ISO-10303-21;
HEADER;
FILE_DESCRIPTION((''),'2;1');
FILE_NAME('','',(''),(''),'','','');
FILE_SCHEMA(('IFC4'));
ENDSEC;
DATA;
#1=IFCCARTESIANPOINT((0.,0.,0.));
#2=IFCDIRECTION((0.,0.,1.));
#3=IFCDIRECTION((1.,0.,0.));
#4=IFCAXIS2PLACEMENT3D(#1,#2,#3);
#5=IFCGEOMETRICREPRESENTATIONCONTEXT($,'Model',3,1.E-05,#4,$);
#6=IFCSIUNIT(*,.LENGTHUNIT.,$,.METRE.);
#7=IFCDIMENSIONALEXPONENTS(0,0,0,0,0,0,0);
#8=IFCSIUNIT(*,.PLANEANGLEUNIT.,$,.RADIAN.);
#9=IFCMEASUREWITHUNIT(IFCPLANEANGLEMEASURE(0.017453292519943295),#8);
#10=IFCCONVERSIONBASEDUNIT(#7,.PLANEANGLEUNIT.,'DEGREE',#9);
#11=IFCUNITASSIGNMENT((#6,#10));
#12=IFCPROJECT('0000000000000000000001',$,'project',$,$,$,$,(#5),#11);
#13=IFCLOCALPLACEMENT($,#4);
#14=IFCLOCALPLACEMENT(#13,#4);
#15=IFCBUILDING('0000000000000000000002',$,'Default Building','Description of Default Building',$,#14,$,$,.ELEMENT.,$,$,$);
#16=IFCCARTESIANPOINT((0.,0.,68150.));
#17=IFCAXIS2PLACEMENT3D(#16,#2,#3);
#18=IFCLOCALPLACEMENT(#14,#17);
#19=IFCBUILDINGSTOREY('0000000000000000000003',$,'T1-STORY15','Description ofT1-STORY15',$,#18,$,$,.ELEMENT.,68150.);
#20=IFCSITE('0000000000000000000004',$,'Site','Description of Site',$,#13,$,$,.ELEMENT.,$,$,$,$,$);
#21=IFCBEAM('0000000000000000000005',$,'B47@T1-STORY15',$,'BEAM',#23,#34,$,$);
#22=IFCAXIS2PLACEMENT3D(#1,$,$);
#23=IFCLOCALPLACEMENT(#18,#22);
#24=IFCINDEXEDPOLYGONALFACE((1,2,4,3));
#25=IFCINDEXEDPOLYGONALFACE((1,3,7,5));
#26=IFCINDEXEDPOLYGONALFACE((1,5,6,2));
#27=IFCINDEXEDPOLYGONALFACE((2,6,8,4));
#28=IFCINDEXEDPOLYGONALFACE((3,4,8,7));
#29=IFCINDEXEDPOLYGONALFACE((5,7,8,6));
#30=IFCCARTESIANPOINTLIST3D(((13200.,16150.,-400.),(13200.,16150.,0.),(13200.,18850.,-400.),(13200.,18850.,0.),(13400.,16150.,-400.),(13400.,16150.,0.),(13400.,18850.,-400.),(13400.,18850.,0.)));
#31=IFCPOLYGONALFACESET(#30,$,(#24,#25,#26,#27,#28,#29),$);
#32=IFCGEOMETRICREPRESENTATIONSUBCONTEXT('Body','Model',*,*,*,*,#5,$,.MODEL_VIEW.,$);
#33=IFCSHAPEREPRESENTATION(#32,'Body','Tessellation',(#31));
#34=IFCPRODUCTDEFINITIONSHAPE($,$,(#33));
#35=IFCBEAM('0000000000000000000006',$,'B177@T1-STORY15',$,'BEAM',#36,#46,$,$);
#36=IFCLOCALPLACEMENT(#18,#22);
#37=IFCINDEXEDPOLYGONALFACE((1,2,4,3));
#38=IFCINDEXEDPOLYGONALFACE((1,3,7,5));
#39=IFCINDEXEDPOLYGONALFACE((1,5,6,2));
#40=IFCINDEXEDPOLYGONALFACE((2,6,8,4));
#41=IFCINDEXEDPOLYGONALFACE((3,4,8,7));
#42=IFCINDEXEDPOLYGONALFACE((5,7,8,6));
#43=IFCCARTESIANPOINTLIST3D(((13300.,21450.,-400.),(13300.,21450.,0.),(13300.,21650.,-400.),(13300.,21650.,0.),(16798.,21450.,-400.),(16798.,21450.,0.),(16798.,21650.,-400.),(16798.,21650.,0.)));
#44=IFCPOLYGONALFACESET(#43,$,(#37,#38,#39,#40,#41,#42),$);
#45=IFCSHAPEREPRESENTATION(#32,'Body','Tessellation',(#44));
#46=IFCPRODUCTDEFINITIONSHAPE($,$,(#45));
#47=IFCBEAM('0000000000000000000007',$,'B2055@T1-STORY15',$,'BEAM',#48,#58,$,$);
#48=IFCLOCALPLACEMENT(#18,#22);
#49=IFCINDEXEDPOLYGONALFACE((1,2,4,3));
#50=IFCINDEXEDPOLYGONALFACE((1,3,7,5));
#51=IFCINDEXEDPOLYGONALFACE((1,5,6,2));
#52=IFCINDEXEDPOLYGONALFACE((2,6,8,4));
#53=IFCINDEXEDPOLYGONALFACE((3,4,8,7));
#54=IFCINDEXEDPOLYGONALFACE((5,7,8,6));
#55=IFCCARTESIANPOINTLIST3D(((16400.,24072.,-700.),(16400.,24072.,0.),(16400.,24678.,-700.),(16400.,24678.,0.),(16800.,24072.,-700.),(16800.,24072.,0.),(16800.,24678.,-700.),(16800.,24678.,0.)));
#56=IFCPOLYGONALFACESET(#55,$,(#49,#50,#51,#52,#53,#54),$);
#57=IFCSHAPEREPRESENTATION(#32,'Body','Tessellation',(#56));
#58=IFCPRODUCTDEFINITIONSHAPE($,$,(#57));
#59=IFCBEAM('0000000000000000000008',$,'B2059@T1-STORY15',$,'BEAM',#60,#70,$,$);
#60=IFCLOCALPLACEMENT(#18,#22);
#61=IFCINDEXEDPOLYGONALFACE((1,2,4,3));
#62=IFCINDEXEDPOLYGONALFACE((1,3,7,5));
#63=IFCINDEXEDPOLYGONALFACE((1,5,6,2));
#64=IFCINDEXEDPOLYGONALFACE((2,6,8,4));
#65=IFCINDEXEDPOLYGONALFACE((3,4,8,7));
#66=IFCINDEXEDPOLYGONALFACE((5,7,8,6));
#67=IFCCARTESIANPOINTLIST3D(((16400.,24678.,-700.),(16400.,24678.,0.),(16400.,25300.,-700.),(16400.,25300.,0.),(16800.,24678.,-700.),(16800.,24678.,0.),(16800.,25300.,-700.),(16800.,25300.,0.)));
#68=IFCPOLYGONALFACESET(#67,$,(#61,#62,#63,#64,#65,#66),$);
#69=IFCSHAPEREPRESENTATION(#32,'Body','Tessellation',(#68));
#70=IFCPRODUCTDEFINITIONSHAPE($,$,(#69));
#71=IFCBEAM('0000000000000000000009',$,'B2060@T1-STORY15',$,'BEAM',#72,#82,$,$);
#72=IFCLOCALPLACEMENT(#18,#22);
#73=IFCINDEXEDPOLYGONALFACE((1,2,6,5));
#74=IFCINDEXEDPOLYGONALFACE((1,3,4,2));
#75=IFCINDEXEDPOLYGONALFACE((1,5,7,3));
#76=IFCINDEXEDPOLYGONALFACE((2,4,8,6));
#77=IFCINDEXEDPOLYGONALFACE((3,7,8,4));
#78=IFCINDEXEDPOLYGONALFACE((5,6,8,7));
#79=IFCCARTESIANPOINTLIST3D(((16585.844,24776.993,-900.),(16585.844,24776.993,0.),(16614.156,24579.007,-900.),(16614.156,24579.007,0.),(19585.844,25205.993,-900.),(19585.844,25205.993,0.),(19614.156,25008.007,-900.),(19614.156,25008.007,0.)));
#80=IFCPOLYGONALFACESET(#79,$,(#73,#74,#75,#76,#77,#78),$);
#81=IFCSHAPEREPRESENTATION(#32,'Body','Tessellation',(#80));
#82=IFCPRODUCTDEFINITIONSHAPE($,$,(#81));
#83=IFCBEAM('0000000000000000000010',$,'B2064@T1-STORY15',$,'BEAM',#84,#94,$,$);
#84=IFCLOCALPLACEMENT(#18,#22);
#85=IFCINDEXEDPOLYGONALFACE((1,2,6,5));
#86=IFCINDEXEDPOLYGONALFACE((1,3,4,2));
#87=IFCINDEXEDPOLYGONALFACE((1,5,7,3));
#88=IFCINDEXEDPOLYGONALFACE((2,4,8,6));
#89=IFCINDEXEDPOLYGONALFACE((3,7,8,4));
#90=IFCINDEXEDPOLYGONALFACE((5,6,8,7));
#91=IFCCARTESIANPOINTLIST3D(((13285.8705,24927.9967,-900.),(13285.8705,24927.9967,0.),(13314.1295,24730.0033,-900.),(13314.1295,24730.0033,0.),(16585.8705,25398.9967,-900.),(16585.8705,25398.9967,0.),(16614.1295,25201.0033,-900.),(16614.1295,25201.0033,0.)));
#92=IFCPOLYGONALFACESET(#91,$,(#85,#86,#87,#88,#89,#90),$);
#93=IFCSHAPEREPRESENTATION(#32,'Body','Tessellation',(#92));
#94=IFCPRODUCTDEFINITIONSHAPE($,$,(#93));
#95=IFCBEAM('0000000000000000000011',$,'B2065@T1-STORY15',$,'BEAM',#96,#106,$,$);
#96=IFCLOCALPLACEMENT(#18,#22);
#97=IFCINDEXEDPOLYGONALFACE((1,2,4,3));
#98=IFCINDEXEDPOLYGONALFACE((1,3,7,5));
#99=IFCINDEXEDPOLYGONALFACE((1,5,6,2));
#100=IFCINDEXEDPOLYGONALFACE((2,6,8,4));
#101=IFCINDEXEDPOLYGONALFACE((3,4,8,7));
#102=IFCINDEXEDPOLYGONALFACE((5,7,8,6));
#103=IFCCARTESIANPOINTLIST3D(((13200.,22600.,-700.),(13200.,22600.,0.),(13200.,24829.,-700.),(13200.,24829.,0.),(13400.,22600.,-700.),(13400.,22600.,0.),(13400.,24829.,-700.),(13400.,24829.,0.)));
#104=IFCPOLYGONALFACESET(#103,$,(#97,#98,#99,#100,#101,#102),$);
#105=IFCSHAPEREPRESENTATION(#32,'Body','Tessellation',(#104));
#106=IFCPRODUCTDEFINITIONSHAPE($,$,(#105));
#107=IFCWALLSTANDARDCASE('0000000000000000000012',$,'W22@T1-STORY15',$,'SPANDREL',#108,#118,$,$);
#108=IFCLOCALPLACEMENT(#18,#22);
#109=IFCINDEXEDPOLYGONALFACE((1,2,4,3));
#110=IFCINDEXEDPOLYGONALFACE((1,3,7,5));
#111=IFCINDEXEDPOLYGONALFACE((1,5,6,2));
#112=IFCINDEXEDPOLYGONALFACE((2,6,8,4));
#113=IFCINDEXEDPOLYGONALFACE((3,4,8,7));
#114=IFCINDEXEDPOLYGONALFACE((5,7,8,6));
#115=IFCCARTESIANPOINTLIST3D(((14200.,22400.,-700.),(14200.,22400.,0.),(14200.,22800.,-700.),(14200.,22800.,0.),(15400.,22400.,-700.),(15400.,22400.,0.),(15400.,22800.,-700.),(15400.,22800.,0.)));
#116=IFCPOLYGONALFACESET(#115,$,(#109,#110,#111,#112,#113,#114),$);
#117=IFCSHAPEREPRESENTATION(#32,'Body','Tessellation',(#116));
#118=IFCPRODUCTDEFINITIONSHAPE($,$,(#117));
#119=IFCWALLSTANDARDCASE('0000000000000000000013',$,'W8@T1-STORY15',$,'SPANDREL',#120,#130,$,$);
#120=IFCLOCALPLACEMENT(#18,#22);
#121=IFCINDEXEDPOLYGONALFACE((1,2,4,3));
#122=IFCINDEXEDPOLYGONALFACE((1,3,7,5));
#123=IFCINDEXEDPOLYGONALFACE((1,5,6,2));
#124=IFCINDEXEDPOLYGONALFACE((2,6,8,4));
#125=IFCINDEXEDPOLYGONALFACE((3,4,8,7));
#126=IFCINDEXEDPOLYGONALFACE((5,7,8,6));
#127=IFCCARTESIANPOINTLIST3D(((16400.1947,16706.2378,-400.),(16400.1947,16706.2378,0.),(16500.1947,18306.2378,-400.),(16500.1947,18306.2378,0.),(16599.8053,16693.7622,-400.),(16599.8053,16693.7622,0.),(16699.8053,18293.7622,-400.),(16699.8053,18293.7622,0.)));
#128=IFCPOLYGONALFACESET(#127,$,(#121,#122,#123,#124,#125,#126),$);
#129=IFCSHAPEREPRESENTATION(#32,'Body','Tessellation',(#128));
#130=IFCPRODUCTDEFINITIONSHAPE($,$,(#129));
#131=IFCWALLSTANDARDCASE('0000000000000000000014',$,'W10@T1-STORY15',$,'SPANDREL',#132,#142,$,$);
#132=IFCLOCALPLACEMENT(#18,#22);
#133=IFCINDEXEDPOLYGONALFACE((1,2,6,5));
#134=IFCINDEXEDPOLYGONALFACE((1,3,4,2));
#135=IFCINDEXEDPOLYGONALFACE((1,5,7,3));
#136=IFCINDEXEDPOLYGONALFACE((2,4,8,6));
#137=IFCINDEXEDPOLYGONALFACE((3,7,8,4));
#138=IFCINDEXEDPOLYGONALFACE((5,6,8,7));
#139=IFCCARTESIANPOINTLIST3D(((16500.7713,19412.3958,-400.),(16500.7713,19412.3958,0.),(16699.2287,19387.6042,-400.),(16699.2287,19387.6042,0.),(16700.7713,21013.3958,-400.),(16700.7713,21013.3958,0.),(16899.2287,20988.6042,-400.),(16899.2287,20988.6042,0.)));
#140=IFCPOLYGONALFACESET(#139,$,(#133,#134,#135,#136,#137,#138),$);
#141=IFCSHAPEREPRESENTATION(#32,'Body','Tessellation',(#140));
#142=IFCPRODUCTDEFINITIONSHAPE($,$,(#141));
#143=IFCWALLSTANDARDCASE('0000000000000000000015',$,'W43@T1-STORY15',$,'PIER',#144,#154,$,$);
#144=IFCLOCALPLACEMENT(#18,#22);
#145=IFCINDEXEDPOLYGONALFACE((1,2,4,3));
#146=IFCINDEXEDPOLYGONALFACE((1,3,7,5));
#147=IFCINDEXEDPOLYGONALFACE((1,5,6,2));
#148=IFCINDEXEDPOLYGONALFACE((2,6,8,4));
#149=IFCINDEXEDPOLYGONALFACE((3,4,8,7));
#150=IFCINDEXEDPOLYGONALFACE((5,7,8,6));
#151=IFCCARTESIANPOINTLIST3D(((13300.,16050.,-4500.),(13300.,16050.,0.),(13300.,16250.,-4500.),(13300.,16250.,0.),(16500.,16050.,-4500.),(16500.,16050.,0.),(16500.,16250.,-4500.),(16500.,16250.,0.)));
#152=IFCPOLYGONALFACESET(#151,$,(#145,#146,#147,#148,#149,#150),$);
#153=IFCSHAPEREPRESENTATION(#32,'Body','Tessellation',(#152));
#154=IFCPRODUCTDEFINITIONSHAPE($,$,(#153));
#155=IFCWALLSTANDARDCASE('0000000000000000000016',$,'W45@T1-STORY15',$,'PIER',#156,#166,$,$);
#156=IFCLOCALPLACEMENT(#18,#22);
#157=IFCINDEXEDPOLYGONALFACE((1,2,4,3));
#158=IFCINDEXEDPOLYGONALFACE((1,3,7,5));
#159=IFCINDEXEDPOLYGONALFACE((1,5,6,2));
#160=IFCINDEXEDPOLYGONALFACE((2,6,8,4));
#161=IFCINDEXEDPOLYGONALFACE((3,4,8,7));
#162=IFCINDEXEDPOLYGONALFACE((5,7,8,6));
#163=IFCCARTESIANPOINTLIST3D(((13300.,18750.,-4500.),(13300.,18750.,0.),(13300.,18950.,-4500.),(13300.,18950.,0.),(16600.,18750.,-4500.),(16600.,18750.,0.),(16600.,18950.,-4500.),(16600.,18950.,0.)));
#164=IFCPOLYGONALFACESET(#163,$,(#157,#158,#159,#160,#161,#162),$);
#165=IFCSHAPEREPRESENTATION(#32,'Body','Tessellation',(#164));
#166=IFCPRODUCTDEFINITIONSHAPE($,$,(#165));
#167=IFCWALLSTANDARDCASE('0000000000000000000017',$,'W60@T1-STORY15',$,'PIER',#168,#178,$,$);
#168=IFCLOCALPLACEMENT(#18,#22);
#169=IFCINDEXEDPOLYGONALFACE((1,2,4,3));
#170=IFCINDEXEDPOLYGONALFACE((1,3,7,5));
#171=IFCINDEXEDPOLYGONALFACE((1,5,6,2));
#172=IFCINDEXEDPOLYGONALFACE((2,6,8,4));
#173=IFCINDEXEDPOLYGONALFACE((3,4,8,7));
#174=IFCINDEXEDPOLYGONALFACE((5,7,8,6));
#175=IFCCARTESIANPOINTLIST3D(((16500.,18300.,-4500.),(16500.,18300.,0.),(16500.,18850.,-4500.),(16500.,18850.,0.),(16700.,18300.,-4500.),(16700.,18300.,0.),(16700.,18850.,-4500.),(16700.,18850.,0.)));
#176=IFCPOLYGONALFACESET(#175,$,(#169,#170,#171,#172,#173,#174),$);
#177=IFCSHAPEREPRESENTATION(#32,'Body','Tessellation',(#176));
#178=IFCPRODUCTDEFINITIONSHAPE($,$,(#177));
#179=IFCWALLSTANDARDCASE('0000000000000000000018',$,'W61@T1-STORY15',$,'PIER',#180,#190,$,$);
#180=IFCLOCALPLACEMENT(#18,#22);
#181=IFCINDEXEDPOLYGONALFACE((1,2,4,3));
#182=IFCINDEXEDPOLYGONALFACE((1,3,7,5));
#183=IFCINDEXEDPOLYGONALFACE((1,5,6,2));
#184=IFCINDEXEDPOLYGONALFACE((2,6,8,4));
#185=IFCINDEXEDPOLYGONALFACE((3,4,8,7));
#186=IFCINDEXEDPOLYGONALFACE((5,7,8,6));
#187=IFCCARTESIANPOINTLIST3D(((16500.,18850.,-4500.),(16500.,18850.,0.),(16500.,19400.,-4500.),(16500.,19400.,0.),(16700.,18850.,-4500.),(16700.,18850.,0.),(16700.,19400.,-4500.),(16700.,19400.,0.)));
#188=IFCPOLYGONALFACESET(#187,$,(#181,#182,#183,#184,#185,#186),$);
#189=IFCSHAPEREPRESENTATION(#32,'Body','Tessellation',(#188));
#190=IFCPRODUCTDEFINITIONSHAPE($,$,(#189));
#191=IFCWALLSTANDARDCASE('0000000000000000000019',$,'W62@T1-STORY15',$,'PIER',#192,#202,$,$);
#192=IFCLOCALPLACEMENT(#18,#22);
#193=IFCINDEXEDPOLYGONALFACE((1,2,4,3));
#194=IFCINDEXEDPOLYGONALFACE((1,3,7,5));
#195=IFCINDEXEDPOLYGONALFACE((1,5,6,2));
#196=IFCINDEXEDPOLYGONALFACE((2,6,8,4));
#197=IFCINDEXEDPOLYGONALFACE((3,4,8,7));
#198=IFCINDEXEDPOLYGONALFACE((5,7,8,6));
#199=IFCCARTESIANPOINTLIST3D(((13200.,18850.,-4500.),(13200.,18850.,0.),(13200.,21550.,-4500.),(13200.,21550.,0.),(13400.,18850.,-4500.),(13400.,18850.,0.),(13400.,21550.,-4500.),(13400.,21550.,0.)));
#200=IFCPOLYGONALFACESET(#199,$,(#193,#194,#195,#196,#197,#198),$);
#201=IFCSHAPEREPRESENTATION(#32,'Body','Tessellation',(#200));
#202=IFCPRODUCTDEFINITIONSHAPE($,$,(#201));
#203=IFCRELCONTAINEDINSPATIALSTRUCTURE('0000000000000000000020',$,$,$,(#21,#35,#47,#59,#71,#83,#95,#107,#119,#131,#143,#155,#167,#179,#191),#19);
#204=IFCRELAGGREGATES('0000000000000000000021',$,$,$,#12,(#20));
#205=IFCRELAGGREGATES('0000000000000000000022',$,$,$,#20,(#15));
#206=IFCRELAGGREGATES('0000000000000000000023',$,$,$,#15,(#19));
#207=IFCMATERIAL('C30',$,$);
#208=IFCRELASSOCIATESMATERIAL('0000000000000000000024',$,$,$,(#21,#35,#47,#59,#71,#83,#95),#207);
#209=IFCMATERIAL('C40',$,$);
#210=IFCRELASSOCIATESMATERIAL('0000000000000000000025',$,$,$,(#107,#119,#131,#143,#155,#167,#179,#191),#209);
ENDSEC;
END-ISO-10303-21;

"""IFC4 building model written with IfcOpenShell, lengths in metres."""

from ifc_helpers import new_model, entity, si_unit, converted_unit, frame, origin_with_axes, place, context, subcontext, project, spatial, indexed_curve, rectangle, outline, extrude, material, element, save


model = new_model("IFC4")

# Units and contexts
model_context = context("Model", 3, precision=1e-05, world=origin_with_axes())
body_context = subcontext(model_context, "Body", "Model", "MODEL_VIEW")
ifc_project = project(units=[si_unit("LENGTHUNIT", "METRE"), converted_unit("PLANEANGLEUNIT", "DEGREE", entity("IfcPlaneAngleMeasure", 0.017453292519943295), si_unit("PLANEANGLEUNIT", "RADIAN"), dimensions=[0, 0, 0, 0, 0, 0, 0])], contexts=[model_context])

# Site, building, storey
site_placement = place(None, origin_with_axes())
site = spatial("IfcSite", under=ifc_project, at=site_placement, Name="Site", Description="Description of Site", CompositionType="ELEMENT")
building_placement = place(site_placement, origin_with_axes())
building = spatial("IfcBuilding", under=site, at=building_placement, Name="Default Building", Description="Description of Default Building", CompositionType="ELEMENT")
storey_placement = place(building_placement, frame((0.0, 0.0, 68150.0), z_axis=(0.0, 0.0, 1.0), x_axis=(1.0, 0.0, 0.0)))
storey = spatial("IfcBuildingStorey", under=building, at=storey_placement, Name="T1-STORY15", Description="Description ofT1-STORY15", CompositionType="ELEMENT", Elevation=68150.0)

# Beams
ifc_material_1 = material(Name="C30")
beam_1_placement = place(storey_placement, frame((13300.0, 16150.0, -200.0), z_axis=(0.0, 1.0, 0.0), x_axis=(-1.0, 0.0, 0.0)))
element("IfcBeam", 1, at=beam_1_placement, inside=storey, material=ifc_material_1, Name="B47@T1-STORY15", ObjectType="BEAM", context=body_context, shape_type="SweptSolid", body=[
    extrude(rectangle(XDim=200.0, YDim=400.0), origin_with_axes(), (0.0, 0.0, 1.0), 2700.0),
])
beam_2_placement = place(storey_placement, frame((13300.0, 21550.0, -200.0), z_axis=(1.0, 0.0, 0.0), x_axis=(0.0, 1.0, 0.0)))
element("IfcBeam", 2, at=beam_2_placement, inside=storey, material=ifc_material_1, Name="B177@T1-STORY15", ObjectType="BEAM", context=body_context, shape_type="SweptSolid", body=[
    extrude(rectangle(XDim=200.0, YDim=400.0), origin_with_axes(), (0.0, 0.0, 1.0), 3498.0),
])
beam_3_placement = place(storey_placement, frame((16600.0, 24072.0, -350.0), z_axis=(0.0, 1.0, 0.0), x_axis=(-1.0, 0.0, 0.0)))
element("IfcBeam", 3, at=beam_3_placement, inside=storey, material=ifc_material_1, Name="B2055@T1-STORY15", ObjectType="BEAM", context=body_context, shape_type="SweptSolid", body=[
    extrude(rectangle(XDim=400.0, YDim=700.0), origin_with_axes(), (0.0, 0.0, 1.0), 606.0),
])
beam_4_placement = place(storey_placement, frame((16600.0, 24678.0, -350.0), z_axis=(0.0, 1.0, 0.0), x_axis=(-1.0, 0.0, 0.0)))
element("IfcBeam", 4, at=beam_4_placement, inside=storey, material=ifc_material_1, Name="B2059@T1-STORY15", ObjectType="BEAM", context=body_context, shape_type="SweptSolid", body=[
    extrude(rectangle(XDim=400.0, YDim=700.0), origin_with_axes(), (0.0, 0.0, 1.0), 622.0),
])
beam_5_placement = place(storey_placement, frame((16600.0, 24678.0, -450.0), z_axis=(0.98993, 0.14156, 0.0), x_axis=(-0.14156, 0.98993, 0.0)))
element("IfcBeam", 5, at=beam_5_placement, inside=storey, material=ifc_material_1, Name="B2060@T1-STORY15", ObjectType="BEAM", context=body_context, shape_type="SweptSolid", body=[
    extrude(rectangle(XDim=200.0, YDim=900.0), origin_with_axes(), (0.0, 0.0, 1.0), 3030.5183),
])
beam_6_placement = place(storey_placement, frame((13300.0, 24829.0, -450.0), z_axis=(0.989967, 0.141295, 0.0), x_axis=(-0.141295, 0.989967, 0.0)))
element("IfcBeam", 6, at=beam_6_placement, inside=storey, material=ifc_material_1, Name="B2064@T1-STORY15", ObjectType="BEAM", context=body_context, shape_type="SweptSolid", body=[
    extrude(rectangle(XDim=200.0, YDim=900.0), origin_with_axes(), (0.0, 0.0, 1.0), 3333.4428),
])
beam_7_placement = place(storey_placement, frame((13300.0, 22600.0, -350.0), z_axis=(0.0, 1.0, 0.0), x_axis=(-1.0, 0.0, 0.0)))
element("IfcBeam", 7, at=beam_7_placement, inside=storey, material=ifc_material_1, Name="B2065@T1-STORY15", ObjectType="BEAM", context=body_context, shape_type="SweptSolid", body=[
    extrude(rectangle(XDim=200.0, YDim=700.0), origin_with_axes(), (0.0, 0.0, 1.0), 2229.0),
])

# Walls
ifc_material_2 = material(Name="C40")
wall_1_placement = place(storey_placement, frame((14200.0, 22600.0, -700.0), z_axis=(0.0, 0.0, 1.0), x_axis=(1.0, 0.0, 0.0)))
element("IfcWallStandardCase", 8, at=wall_1_placement, inside=storey, material=ifc_material_2, Name="W22@T1-STORY15", ObjectType="SPANDREL", context=body_context, shape_type="SweptSolid", body=[
    extrude(outline(indexed_curve([(0.0, -200.0), (0.0, 200.0), (1200.0, 200.0), (1200.0, -200.0), (0.0, -200.0)], self_intersect=False)), origin_with_axes(), (0.0, 0.0, 1.0), 700.0),
])
wall_2_placement = place(storey_placement, frame((16500.0, 16700.0, -400.0), z_axis=(0.0, 0.0, 1.0), x_axis=(0.062378, 0.998053, 0.0)))
element("IfcWallStandardCase", 9, at=wall_2_placement, inside=storey, material=ifc_material_2, Name="W8@T1-STORY15", ObjectType="SPANDREL", context=body_context, shape_type="SweptSolid", body=[
    extrude(outline(indexed_curve([(0.0, -100.0), (0.0, 100.0), (1603.122, 100.0), (1603.122, -100.0), (0.0, -100.0)], self_intersect=False)), origin_with_axes(), (0.0, 0.0, 1.0), 400.0),
])
wall_3_placement = place(storey_placement, frame((16600.0, 19400.0, -400.0), z_axis=(0.0, 0.0, 1.0), x_axis=(0.123958, 0.992287, 0.0)))
element("IfcWallStandardCase", 10, at=wall_3_placement, inside=storey, material=ifc_material_2, Name="W10@T1-STORY15", ObjectType="SPANDREL", context=body_context, shape_type="SweptSolid", body=[
    extrude(outline(indexed_curve([(0.0, -100.0), (0.0, 100.0), (1613.4438, 100.0), (1613.4438, -100.0), (0.0, -100.0)], self_intersect=False)), origin_with_axes(), (0.0, 0.0, 1.0), 400.0),
])
wall_4_placement = place(storey_placement, frame((13300.0, 16150.0, -4500.0), z_axis=(0.0, 0.0, 1.0), x_axis=(1.0, 0.0, 0.0)))
element("IfcWallStandardCase", 11, at=wall_4_placement, inside=storey, material=ifc_material_2, Name="W43@T1-STORY15", ObjectType="PIER", context=body_context, shape_type="SweptSolid", body=[
    extrude(outline(indexed_curve([(0.0, -100.0), (0.0, 100.0), (3200.0, 100.0), (3200.0, -100.0), (0.0, -100.0)], self_intersect=False)), origin_with_axes(), (0.0, 0.0, 1.0), 4500.0),
])
wall_5_placement = place(storey_placement, frame((13300.0, 18850.0, -4500.0), z_axis=(0.0, 0.0, 1.0), x_axis=(1.0, 0.0, 0.0)))
element("IfcWallStandardCase", 12, at=wall_5_placement, inside=storey, material=ifc_material_2, Name="W45@T1-STORY15", ObjectType="PIER", context=body_context, shape_type="SweptSolid", body=[
    extrude(outline(indexed_curve([(0.0, -100.0), (0.0, 100.0), (3300.0, 100.0), (3300.0, -100.0), (0.0, -100.0)], self_intersect=False)), origin_with_axes(), (0.0, 0.0, 1.0), 4500.0),
])
for number, where, z_axis, x_axis, name in (
    (13, (16600.0, 18300.0, -4500.0), (0.0, 0.0, 1.0), (0.0, 1.0, 0.0), "W60@T1-STORY15"),
    (14, (16600.0, 18850.0, -4500.0), (0.0, 0.0, 1.0), (0.0, 1.0, 0.0), "W61@T1-STORY15"),
):
    element("IfcWallStandardCase", number, at=place(storey_placement, frame(where, z_axis=z_axis, x_axis=x_axis)), inside=storey, material=ifc_material_2, Name=name, ObjectType="PIER", context=body_context, shape_type="SweptSolid", body=[
        extrude(outline(indexed_curve([(0.0, -100.0), (0.0, 100.0), (550.0, 100.0), (550.0, -100.0), (0.0, -100.0)], self_intersect=False)), origin_with_axes(), (0.0, 0.0, 1.0), 4500.0),
    ])
wall_6_placement = place(storey_placement, frame((13300.0, 18850.0, -4500.0), z_axis=(0.0, 0.0, 1.0), x_axis=(0.0, 1.0, 0.0)))
element("IfcWallStandardCase", 15, at=wall_6_placement, inside=storey, material=ifc_material_2, Name="W62@T1-STORY15", ObjectType="PIER", context=body_context, shape_type="SweptSolid", body=[
    extrude(outline(indexed_curve([(0.0, -100.0), (0.0, 100.0), (2700.0, 100.0), (2700.0, -100.0), (0.0, -100.0)], self_intersect=False)), origin_with_axes(), (0.0, 0.0, 1.0), 4500.0),
])

save(model, "model.ifc")
